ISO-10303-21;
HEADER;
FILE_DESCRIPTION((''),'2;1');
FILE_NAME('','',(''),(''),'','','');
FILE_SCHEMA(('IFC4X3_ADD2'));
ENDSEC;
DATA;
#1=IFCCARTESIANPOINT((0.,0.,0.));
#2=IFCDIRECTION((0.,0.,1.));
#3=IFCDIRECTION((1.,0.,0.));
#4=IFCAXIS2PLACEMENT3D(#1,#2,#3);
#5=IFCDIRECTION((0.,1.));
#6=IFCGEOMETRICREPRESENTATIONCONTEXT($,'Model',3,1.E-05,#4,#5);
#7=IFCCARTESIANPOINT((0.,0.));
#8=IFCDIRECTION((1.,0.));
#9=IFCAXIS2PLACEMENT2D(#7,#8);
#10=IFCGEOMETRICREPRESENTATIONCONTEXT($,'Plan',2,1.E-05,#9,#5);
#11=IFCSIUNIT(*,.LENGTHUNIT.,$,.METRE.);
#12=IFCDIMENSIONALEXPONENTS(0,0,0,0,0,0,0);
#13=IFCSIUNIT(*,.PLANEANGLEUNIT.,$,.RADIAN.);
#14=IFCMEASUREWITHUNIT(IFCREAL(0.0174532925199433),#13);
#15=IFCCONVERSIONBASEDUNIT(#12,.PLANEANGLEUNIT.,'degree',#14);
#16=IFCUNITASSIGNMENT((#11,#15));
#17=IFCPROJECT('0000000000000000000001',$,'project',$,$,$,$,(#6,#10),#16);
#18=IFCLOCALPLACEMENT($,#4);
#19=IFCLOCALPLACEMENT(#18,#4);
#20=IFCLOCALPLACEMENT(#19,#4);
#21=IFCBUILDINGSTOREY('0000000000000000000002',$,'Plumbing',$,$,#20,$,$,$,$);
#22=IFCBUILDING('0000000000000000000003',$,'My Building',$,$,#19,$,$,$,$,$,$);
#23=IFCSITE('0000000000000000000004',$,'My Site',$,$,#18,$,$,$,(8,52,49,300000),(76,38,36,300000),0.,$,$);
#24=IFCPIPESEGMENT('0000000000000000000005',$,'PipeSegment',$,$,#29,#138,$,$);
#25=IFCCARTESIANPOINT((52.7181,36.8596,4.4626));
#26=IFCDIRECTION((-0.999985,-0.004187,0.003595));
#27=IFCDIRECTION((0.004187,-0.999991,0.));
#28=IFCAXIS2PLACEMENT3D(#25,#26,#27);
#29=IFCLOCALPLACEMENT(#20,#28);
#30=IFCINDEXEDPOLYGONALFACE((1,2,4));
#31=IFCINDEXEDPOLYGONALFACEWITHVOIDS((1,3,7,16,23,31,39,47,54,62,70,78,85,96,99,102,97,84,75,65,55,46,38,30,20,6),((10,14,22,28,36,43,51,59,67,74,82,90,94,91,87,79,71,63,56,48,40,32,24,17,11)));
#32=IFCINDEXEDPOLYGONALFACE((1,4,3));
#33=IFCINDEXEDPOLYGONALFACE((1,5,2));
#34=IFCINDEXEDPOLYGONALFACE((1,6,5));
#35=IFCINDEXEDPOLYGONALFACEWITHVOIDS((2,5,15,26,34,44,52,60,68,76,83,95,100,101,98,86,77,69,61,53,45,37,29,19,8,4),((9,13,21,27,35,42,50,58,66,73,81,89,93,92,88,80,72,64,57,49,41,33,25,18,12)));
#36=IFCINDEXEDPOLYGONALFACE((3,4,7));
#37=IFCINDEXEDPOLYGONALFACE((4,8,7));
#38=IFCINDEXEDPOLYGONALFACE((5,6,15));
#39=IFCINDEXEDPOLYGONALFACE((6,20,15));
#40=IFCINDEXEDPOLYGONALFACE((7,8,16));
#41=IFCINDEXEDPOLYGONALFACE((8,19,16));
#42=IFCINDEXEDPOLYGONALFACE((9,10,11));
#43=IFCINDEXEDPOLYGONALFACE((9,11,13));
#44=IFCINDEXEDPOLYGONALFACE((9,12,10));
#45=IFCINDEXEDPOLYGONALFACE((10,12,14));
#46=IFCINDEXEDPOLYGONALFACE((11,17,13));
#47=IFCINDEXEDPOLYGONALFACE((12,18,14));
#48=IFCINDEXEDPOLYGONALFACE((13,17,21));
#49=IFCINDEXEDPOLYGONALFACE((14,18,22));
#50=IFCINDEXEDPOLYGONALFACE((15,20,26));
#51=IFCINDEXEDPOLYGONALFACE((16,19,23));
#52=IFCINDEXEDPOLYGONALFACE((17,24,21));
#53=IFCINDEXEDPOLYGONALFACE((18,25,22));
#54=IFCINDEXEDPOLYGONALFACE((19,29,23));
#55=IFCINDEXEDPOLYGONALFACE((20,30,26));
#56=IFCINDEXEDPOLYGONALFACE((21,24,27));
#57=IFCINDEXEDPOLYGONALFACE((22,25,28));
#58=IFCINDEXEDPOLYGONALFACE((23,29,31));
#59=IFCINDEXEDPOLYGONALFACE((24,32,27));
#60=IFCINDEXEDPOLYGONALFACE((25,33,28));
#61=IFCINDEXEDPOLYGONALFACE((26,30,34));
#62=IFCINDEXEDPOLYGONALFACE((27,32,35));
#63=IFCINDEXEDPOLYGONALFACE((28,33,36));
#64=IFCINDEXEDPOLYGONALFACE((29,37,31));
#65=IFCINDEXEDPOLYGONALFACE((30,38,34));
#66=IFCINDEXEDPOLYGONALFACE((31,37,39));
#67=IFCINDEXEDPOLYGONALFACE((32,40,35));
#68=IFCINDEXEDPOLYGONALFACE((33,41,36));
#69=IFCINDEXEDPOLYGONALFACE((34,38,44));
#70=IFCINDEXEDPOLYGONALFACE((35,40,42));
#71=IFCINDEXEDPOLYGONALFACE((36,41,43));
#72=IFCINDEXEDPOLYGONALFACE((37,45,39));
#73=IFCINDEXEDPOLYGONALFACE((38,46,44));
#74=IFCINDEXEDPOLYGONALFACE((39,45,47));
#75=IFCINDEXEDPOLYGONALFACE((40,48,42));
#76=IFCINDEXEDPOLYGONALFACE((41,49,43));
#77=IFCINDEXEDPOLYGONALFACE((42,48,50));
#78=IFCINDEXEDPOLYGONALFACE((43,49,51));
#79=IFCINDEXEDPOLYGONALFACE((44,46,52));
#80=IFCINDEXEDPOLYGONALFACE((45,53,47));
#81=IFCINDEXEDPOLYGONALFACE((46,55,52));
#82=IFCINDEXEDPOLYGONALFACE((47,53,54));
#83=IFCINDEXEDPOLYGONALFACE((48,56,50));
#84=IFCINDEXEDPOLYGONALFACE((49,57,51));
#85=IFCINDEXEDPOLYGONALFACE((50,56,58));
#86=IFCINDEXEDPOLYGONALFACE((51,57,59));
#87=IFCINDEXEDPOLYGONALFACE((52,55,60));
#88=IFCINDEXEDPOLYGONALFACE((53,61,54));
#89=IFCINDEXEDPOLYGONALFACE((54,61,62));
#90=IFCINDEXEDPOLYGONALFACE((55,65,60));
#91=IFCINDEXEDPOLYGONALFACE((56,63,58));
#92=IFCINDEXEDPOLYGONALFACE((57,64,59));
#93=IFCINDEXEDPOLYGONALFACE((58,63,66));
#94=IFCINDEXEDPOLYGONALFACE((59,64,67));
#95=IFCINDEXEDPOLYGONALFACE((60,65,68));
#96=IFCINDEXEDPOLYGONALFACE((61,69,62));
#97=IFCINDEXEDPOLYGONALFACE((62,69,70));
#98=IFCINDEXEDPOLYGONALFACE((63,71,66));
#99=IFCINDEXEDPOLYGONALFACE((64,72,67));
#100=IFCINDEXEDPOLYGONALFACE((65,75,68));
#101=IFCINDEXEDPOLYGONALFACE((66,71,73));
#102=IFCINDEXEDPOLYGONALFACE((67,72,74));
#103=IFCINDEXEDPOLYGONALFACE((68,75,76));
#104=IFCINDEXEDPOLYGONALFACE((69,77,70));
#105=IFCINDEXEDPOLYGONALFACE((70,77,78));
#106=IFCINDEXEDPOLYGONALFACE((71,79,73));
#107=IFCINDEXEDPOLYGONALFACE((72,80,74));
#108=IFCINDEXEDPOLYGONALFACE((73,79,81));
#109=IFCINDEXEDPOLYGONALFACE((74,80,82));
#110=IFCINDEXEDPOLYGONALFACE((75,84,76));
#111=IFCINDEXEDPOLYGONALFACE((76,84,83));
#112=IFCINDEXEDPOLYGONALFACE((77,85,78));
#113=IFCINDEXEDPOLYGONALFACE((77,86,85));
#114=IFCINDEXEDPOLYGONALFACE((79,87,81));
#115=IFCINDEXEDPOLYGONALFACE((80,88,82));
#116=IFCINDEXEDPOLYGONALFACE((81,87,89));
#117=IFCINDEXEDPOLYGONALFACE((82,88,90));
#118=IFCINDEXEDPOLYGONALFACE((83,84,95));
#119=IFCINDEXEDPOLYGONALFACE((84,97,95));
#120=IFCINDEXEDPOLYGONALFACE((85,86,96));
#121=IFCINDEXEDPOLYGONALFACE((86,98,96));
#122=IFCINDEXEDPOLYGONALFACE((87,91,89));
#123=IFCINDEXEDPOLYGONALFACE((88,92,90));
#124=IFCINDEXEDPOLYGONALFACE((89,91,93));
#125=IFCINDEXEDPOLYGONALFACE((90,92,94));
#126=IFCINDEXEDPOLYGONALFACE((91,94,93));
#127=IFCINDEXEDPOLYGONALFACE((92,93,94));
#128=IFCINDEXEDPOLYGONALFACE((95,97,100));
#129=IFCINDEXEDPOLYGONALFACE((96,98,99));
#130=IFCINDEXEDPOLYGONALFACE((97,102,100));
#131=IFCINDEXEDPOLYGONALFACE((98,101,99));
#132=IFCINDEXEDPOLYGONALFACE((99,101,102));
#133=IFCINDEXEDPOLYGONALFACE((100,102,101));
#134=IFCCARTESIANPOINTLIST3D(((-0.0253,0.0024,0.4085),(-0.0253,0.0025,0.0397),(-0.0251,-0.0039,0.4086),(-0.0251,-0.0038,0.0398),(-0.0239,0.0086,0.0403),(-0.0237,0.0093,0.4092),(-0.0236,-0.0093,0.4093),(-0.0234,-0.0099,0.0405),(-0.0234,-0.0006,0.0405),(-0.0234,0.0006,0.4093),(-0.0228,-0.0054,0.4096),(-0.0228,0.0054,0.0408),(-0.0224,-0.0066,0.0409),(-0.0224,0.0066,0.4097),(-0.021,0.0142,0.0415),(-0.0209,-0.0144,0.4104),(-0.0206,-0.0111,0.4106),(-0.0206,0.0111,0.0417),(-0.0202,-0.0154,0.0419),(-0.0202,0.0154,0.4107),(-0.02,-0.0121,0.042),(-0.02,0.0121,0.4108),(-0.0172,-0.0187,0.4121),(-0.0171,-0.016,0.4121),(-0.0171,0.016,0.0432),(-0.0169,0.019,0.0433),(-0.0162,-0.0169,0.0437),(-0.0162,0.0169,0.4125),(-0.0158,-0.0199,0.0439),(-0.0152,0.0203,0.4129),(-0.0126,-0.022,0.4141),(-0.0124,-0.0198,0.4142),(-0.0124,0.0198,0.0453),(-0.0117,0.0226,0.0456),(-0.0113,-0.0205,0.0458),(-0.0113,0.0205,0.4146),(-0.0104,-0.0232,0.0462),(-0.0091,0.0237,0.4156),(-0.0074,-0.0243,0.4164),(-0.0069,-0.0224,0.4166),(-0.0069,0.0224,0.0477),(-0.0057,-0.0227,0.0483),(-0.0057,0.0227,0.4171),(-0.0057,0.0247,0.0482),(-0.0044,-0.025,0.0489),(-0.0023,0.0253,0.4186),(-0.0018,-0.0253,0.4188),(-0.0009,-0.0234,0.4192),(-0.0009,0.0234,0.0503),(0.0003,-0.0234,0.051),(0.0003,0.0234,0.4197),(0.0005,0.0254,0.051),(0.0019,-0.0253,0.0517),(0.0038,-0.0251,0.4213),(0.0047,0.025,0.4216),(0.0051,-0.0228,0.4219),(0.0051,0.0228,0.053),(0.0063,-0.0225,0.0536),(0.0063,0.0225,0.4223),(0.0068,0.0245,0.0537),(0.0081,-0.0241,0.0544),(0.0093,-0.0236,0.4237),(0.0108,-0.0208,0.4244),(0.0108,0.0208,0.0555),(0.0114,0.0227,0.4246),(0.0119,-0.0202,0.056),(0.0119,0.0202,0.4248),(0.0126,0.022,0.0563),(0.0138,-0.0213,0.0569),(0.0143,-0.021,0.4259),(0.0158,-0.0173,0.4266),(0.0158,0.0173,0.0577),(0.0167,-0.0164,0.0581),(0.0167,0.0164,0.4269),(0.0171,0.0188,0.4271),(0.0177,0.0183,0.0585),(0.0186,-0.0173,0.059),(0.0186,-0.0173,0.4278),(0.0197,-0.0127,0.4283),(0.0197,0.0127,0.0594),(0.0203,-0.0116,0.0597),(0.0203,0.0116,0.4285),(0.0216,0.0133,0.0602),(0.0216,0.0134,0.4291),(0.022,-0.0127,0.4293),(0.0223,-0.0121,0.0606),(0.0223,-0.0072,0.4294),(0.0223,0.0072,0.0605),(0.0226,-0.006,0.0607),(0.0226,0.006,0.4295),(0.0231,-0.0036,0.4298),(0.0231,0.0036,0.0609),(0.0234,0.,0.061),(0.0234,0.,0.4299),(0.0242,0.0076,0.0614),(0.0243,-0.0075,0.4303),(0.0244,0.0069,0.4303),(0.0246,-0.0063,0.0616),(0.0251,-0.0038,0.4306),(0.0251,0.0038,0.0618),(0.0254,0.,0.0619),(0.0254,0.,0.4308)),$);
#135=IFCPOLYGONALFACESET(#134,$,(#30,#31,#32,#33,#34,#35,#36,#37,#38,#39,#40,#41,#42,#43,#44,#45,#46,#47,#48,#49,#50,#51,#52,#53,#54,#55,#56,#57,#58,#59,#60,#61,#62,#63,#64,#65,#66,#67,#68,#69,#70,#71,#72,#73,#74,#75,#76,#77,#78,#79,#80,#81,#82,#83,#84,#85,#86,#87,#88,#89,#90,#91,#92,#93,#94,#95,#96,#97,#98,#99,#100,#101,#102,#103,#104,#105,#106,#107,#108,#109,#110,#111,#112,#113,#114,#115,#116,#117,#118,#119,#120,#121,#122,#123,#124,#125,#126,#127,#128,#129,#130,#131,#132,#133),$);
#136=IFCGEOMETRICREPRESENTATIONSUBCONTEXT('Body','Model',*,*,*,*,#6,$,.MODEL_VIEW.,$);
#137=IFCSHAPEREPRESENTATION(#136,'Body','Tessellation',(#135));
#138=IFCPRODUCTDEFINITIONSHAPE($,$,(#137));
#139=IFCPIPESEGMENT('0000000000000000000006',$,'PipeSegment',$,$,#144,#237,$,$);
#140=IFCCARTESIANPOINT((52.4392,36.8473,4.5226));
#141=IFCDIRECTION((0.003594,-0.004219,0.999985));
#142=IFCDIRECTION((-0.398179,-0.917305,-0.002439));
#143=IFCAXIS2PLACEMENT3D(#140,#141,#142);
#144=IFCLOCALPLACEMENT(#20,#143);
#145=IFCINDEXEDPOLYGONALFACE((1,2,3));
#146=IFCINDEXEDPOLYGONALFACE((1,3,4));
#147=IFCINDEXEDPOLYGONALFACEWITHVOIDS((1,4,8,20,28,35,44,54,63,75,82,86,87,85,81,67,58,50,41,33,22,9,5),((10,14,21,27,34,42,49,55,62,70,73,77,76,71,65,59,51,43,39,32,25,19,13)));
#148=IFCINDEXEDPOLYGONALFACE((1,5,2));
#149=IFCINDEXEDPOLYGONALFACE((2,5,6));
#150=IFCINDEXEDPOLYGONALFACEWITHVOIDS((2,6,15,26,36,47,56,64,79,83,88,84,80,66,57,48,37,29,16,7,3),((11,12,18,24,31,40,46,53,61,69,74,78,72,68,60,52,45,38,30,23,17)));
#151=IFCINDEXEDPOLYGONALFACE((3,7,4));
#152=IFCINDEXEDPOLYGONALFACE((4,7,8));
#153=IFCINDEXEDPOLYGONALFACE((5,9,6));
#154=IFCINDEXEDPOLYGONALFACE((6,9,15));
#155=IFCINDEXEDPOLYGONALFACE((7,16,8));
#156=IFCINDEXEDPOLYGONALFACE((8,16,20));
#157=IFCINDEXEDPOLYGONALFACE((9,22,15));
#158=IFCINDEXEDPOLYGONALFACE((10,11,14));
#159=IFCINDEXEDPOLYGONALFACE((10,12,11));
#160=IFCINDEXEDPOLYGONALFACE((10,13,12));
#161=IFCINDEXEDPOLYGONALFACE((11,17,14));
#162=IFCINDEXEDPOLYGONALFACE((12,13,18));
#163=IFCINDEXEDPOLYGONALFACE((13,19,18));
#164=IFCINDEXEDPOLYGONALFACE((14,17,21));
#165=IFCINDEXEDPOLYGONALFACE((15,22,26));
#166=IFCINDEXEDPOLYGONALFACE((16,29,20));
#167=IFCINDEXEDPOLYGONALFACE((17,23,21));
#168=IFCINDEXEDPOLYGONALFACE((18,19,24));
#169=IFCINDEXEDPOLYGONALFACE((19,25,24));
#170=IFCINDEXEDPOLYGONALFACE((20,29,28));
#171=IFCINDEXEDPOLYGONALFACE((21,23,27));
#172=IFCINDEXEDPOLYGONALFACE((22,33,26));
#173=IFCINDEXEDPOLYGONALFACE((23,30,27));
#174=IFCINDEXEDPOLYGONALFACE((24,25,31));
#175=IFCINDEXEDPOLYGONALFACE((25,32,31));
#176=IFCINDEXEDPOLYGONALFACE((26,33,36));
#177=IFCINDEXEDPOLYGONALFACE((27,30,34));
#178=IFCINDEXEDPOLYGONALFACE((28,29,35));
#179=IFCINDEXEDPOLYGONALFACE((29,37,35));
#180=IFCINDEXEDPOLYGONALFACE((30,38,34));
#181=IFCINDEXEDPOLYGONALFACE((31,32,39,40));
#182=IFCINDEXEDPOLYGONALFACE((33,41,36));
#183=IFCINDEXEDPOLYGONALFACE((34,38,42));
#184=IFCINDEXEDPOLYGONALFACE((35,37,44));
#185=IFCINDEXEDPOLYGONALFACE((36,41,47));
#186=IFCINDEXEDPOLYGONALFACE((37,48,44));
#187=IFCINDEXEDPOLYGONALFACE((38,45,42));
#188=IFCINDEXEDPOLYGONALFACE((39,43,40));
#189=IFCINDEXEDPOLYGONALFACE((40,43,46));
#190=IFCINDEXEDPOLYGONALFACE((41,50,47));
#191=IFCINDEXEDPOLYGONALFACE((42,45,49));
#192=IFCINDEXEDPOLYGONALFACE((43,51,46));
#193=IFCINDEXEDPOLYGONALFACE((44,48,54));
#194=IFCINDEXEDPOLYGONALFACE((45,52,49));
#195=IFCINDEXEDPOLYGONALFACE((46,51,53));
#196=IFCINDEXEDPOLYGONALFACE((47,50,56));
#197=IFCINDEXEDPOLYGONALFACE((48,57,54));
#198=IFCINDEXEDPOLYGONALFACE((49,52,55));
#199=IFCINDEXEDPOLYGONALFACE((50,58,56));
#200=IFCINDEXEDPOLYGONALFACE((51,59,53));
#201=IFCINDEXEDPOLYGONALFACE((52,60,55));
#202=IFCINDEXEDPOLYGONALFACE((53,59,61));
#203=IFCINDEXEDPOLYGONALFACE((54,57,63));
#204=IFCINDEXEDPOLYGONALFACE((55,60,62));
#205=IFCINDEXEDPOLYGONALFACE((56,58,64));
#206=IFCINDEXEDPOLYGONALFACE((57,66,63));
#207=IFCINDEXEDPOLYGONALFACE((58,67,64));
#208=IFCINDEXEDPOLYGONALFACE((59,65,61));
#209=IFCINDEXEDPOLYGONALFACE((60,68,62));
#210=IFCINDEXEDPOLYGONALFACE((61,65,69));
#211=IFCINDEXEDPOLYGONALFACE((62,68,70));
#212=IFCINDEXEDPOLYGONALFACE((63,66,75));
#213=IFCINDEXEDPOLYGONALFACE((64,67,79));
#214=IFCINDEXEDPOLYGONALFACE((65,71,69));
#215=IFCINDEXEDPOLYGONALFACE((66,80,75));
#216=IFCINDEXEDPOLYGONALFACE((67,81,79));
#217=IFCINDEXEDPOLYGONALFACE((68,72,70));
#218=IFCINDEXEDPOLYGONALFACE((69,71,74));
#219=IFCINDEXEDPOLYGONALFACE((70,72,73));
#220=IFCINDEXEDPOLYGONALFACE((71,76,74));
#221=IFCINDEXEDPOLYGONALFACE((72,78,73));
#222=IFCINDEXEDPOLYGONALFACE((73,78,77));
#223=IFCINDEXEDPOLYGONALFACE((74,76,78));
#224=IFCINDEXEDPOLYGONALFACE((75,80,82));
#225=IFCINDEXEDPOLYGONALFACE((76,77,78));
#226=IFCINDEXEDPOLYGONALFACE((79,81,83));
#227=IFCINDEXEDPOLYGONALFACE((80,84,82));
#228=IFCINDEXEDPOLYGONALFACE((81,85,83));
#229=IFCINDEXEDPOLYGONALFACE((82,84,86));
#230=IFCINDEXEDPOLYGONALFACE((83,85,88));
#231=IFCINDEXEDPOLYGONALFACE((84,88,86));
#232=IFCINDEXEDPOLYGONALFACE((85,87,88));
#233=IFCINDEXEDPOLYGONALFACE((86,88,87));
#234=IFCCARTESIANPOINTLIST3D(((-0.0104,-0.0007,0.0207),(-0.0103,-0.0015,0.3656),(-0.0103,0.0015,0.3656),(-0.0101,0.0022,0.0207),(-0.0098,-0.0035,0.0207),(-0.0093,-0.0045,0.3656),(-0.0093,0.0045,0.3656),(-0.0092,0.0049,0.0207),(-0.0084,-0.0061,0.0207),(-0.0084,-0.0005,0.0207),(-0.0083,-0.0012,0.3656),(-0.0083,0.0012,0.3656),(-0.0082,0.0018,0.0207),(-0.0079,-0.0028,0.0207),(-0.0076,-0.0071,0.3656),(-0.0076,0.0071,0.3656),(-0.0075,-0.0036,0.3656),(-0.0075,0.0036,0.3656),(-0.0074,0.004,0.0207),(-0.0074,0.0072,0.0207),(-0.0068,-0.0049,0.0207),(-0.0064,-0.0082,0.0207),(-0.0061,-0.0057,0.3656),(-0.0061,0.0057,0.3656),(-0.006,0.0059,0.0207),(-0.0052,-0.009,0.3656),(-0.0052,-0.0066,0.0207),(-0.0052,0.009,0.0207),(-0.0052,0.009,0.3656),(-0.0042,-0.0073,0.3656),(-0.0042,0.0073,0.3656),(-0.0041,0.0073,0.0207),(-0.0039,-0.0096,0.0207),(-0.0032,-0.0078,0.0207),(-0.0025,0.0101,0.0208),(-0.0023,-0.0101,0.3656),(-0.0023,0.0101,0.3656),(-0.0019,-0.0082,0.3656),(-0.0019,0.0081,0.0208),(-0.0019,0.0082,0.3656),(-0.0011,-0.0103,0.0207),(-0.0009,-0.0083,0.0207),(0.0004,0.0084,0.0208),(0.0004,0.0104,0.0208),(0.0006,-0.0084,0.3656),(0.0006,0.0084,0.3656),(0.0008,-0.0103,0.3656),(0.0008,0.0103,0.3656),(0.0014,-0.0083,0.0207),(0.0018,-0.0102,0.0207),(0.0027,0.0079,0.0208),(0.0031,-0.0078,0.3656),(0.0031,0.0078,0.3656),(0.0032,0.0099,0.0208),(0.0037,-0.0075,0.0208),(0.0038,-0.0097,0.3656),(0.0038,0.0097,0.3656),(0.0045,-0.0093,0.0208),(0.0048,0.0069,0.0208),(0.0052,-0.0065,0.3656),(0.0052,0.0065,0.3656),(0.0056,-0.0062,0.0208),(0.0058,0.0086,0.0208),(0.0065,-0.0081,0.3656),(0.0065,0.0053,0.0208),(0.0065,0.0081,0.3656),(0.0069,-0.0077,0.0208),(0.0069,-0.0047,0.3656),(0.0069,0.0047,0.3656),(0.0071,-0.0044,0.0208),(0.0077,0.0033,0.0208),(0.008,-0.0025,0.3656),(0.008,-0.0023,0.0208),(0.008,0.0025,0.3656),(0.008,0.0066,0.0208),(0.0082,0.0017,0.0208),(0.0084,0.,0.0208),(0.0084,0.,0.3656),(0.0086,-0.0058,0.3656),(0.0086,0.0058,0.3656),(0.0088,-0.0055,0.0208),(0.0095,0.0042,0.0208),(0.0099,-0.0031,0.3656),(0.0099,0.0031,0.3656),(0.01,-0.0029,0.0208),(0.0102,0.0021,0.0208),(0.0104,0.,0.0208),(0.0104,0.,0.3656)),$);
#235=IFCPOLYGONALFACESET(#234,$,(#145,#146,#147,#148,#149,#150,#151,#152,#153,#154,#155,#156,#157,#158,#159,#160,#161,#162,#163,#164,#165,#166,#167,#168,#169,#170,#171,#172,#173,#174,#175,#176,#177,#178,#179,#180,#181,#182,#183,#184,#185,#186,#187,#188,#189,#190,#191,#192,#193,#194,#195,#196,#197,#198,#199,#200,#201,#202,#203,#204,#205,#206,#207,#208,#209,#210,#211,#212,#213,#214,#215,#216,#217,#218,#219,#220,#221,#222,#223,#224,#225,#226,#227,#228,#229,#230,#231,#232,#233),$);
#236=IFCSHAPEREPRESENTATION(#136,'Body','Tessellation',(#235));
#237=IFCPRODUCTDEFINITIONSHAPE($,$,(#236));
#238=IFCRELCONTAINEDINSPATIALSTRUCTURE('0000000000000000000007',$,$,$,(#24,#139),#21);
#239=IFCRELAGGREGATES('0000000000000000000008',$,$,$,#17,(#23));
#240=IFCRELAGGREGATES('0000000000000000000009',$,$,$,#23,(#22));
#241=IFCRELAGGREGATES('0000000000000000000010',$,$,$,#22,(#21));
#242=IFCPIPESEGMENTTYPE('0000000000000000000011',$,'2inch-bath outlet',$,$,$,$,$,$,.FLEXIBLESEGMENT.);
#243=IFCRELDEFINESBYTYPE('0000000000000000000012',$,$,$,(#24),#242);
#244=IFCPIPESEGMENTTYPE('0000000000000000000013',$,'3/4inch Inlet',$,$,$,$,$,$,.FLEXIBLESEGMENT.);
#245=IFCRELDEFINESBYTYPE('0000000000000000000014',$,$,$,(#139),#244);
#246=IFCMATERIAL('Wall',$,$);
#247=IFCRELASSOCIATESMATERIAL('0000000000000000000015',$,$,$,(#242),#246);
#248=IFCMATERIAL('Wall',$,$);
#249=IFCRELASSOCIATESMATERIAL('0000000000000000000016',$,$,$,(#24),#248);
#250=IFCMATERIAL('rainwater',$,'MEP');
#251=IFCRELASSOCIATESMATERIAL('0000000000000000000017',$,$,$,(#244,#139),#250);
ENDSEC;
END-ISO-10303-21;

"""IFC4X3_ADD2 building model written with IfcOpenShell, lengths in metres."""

from ifc_helpers import new_model, entity, si_unit, converted_unit, direction, frame, origin_with_axes, origin_2d_with_axis, place, context, subcontext, project, spatial, hollow_circle, extrude, clip, halfspace, material, material_profile, profile_set, profile_usage, type_object, element, save


model = new_model("IFC4X3_ADD2")

# Units and contexts
model_context = context("Model", 3, precision=1e-05, world=origin_with_axes(), true_north=direction((0.0, 1.0)))
plan_context = context("Plan", 2, precision=1e-05, world=origin_2d_with_axis(), true_north=direction((0.0, 1.0)))
body_context_1 = subcontext(model_context, "Body", "Model", "MODEL_VIEW")
ifc_project = project(units=[si_unit("LENGTHUNIT", "METRE"), converted_unit("PLANEANGLEUNIT", "degree", entity("IfcReal", 0.0174532925199433), si_unit("PLANEANGLEUNIT", "RADIAN"), dimensions=[0, 0, 0, 0, 0, 0, 0])], contexts=[model_context, plan_context])

# Site, building, storey
site_placement = place(None, origin_with_axes())
site = spatial("IfcSite", under=ifc_project, at=site_placement, Name="My Site", RefLatitude=(8, 52, 49, 300000), RefLongitude=(76, 38, 36, 300000), RefElevation=0.0)
building_placement = place(site_placement, origin_with_axes())
building = spatial("IfcBuilding", under=site, at=building_placement, Name="My Building")
storey_placement = place(building_placement, origin_with_axes())
storey = spatial("IfcBuildingStorey", under=building, at=storey_placement, Name="Plumbing")

# Pipe segment
ifc_material_1 = material(Name="Wall")
ifc_material_profile_1 = material_profile(ifc_material_1, hollow_circle(Radius=0.0254, WallThickness=0.002))
ifc_profile_set_1 = profile_set([ifc_material_profile_1], Name="graywater")
ifc_material_2 = material(Name="Wall")
ifc_material_profile_2 = material_profile(ifc_material_2, hollow_circle(Radius=0.0254, WallThickness=0.002))
ifc_profile_set_2 = profile_set([ifc_material_profile_2], Name="graywater")
pipe_segment_type_1 = type_object("IfcPipeSegmentType", Name="2inch-bath outlet", PredefinedType="FLEXIBLESEGMENT", material=ifc_profile_set_2)
ifc_profile_usage_1 = profile_usage(ifc_profile_set_1, cardinal=5)
pipe_segment_1_placement = place(storey_placement, frame((52.7181, 36.8596, 4.4626), z_axis=(-0.999985, -0.004187, 0.003595), x_axis=(0.004187, -0.999991, 0.0)))
element("IfcPipeSegment", 1, at=pipe_segment_1_placement, inside=storey, type_object=pipe_segment_type_1, material=ifc_profile_usage_1, Name="PipeSegment", context=body_context_1, shape_type="Clipping", body=[
    clip(clip(extrude(hollow_circle(Radius=0.0254, WallThickness=0.002), origin_with_axes(), (0.0, 0.0, 1.0), 0.4704), halfspace(frame((-0.0388, -5.1586, 0.0433), z_axis=(0.402001, -0.001685, -0.915637), x_axis=(-0.004192, -0.999991, 0.0)), False)), halfspace(frame((0.0091, -0.0612, 0.4237), z_axis=(-0.402001, 0.001685, 0.915637), x_axis=(0.004192, 0.999991, 0.0)), False)),
])

# Pipe segment
ifc_material_3 = material(Name="rainwater", Category="MEP")
ifc_material_profile_3 = material_profile(ifc_material_3, hollow_circle(Radius=0.0104, WallThickness=0.002))
ifc_profile_set_3 = profile_set([ifc_material_profile_3], Name="water")
pipe_segment_type_2 = type_object("IfcPipeSegmentType", Name="3/4inch Inlet", PredefinedType="FLEXIBLESEGMENT", material=ifc_profile_set_3)
ifc_profile_usage_2 = profile_usage(ifc_profile_set_3, cardinal=5)
pipe_segment_2_placement = place(storey_placement, frame((52.4392, 36.8473, 4.5226), z_axis=(0.003594, -0.004219, 0.999985), x_axis=(-0.398179, -0.917305, -0.002439)))
element("IfcPipeSegment", 2, at=pipe_segment_2_placement, inside=storey, type_object=pipe_segment_type_2, material=ifc_profile_usage_2, Name="PipeSegment", context=body_context_1, shape_type="Clipping", body=[
    clip(extrude(hollow_circle(Radius=0.0104, WallThickness=0.002), origin_with_axes(), (0.0, 0.0, 1.0), 0.3656), halfspace(frame((-0.1208, 0.2773, 0.0207), z_axis=(0.003884, 0.001685, -0.999991), x_axis=(0.999992, 0.0, 0.003884)), False)),
])

save(model, "model.ifc")
